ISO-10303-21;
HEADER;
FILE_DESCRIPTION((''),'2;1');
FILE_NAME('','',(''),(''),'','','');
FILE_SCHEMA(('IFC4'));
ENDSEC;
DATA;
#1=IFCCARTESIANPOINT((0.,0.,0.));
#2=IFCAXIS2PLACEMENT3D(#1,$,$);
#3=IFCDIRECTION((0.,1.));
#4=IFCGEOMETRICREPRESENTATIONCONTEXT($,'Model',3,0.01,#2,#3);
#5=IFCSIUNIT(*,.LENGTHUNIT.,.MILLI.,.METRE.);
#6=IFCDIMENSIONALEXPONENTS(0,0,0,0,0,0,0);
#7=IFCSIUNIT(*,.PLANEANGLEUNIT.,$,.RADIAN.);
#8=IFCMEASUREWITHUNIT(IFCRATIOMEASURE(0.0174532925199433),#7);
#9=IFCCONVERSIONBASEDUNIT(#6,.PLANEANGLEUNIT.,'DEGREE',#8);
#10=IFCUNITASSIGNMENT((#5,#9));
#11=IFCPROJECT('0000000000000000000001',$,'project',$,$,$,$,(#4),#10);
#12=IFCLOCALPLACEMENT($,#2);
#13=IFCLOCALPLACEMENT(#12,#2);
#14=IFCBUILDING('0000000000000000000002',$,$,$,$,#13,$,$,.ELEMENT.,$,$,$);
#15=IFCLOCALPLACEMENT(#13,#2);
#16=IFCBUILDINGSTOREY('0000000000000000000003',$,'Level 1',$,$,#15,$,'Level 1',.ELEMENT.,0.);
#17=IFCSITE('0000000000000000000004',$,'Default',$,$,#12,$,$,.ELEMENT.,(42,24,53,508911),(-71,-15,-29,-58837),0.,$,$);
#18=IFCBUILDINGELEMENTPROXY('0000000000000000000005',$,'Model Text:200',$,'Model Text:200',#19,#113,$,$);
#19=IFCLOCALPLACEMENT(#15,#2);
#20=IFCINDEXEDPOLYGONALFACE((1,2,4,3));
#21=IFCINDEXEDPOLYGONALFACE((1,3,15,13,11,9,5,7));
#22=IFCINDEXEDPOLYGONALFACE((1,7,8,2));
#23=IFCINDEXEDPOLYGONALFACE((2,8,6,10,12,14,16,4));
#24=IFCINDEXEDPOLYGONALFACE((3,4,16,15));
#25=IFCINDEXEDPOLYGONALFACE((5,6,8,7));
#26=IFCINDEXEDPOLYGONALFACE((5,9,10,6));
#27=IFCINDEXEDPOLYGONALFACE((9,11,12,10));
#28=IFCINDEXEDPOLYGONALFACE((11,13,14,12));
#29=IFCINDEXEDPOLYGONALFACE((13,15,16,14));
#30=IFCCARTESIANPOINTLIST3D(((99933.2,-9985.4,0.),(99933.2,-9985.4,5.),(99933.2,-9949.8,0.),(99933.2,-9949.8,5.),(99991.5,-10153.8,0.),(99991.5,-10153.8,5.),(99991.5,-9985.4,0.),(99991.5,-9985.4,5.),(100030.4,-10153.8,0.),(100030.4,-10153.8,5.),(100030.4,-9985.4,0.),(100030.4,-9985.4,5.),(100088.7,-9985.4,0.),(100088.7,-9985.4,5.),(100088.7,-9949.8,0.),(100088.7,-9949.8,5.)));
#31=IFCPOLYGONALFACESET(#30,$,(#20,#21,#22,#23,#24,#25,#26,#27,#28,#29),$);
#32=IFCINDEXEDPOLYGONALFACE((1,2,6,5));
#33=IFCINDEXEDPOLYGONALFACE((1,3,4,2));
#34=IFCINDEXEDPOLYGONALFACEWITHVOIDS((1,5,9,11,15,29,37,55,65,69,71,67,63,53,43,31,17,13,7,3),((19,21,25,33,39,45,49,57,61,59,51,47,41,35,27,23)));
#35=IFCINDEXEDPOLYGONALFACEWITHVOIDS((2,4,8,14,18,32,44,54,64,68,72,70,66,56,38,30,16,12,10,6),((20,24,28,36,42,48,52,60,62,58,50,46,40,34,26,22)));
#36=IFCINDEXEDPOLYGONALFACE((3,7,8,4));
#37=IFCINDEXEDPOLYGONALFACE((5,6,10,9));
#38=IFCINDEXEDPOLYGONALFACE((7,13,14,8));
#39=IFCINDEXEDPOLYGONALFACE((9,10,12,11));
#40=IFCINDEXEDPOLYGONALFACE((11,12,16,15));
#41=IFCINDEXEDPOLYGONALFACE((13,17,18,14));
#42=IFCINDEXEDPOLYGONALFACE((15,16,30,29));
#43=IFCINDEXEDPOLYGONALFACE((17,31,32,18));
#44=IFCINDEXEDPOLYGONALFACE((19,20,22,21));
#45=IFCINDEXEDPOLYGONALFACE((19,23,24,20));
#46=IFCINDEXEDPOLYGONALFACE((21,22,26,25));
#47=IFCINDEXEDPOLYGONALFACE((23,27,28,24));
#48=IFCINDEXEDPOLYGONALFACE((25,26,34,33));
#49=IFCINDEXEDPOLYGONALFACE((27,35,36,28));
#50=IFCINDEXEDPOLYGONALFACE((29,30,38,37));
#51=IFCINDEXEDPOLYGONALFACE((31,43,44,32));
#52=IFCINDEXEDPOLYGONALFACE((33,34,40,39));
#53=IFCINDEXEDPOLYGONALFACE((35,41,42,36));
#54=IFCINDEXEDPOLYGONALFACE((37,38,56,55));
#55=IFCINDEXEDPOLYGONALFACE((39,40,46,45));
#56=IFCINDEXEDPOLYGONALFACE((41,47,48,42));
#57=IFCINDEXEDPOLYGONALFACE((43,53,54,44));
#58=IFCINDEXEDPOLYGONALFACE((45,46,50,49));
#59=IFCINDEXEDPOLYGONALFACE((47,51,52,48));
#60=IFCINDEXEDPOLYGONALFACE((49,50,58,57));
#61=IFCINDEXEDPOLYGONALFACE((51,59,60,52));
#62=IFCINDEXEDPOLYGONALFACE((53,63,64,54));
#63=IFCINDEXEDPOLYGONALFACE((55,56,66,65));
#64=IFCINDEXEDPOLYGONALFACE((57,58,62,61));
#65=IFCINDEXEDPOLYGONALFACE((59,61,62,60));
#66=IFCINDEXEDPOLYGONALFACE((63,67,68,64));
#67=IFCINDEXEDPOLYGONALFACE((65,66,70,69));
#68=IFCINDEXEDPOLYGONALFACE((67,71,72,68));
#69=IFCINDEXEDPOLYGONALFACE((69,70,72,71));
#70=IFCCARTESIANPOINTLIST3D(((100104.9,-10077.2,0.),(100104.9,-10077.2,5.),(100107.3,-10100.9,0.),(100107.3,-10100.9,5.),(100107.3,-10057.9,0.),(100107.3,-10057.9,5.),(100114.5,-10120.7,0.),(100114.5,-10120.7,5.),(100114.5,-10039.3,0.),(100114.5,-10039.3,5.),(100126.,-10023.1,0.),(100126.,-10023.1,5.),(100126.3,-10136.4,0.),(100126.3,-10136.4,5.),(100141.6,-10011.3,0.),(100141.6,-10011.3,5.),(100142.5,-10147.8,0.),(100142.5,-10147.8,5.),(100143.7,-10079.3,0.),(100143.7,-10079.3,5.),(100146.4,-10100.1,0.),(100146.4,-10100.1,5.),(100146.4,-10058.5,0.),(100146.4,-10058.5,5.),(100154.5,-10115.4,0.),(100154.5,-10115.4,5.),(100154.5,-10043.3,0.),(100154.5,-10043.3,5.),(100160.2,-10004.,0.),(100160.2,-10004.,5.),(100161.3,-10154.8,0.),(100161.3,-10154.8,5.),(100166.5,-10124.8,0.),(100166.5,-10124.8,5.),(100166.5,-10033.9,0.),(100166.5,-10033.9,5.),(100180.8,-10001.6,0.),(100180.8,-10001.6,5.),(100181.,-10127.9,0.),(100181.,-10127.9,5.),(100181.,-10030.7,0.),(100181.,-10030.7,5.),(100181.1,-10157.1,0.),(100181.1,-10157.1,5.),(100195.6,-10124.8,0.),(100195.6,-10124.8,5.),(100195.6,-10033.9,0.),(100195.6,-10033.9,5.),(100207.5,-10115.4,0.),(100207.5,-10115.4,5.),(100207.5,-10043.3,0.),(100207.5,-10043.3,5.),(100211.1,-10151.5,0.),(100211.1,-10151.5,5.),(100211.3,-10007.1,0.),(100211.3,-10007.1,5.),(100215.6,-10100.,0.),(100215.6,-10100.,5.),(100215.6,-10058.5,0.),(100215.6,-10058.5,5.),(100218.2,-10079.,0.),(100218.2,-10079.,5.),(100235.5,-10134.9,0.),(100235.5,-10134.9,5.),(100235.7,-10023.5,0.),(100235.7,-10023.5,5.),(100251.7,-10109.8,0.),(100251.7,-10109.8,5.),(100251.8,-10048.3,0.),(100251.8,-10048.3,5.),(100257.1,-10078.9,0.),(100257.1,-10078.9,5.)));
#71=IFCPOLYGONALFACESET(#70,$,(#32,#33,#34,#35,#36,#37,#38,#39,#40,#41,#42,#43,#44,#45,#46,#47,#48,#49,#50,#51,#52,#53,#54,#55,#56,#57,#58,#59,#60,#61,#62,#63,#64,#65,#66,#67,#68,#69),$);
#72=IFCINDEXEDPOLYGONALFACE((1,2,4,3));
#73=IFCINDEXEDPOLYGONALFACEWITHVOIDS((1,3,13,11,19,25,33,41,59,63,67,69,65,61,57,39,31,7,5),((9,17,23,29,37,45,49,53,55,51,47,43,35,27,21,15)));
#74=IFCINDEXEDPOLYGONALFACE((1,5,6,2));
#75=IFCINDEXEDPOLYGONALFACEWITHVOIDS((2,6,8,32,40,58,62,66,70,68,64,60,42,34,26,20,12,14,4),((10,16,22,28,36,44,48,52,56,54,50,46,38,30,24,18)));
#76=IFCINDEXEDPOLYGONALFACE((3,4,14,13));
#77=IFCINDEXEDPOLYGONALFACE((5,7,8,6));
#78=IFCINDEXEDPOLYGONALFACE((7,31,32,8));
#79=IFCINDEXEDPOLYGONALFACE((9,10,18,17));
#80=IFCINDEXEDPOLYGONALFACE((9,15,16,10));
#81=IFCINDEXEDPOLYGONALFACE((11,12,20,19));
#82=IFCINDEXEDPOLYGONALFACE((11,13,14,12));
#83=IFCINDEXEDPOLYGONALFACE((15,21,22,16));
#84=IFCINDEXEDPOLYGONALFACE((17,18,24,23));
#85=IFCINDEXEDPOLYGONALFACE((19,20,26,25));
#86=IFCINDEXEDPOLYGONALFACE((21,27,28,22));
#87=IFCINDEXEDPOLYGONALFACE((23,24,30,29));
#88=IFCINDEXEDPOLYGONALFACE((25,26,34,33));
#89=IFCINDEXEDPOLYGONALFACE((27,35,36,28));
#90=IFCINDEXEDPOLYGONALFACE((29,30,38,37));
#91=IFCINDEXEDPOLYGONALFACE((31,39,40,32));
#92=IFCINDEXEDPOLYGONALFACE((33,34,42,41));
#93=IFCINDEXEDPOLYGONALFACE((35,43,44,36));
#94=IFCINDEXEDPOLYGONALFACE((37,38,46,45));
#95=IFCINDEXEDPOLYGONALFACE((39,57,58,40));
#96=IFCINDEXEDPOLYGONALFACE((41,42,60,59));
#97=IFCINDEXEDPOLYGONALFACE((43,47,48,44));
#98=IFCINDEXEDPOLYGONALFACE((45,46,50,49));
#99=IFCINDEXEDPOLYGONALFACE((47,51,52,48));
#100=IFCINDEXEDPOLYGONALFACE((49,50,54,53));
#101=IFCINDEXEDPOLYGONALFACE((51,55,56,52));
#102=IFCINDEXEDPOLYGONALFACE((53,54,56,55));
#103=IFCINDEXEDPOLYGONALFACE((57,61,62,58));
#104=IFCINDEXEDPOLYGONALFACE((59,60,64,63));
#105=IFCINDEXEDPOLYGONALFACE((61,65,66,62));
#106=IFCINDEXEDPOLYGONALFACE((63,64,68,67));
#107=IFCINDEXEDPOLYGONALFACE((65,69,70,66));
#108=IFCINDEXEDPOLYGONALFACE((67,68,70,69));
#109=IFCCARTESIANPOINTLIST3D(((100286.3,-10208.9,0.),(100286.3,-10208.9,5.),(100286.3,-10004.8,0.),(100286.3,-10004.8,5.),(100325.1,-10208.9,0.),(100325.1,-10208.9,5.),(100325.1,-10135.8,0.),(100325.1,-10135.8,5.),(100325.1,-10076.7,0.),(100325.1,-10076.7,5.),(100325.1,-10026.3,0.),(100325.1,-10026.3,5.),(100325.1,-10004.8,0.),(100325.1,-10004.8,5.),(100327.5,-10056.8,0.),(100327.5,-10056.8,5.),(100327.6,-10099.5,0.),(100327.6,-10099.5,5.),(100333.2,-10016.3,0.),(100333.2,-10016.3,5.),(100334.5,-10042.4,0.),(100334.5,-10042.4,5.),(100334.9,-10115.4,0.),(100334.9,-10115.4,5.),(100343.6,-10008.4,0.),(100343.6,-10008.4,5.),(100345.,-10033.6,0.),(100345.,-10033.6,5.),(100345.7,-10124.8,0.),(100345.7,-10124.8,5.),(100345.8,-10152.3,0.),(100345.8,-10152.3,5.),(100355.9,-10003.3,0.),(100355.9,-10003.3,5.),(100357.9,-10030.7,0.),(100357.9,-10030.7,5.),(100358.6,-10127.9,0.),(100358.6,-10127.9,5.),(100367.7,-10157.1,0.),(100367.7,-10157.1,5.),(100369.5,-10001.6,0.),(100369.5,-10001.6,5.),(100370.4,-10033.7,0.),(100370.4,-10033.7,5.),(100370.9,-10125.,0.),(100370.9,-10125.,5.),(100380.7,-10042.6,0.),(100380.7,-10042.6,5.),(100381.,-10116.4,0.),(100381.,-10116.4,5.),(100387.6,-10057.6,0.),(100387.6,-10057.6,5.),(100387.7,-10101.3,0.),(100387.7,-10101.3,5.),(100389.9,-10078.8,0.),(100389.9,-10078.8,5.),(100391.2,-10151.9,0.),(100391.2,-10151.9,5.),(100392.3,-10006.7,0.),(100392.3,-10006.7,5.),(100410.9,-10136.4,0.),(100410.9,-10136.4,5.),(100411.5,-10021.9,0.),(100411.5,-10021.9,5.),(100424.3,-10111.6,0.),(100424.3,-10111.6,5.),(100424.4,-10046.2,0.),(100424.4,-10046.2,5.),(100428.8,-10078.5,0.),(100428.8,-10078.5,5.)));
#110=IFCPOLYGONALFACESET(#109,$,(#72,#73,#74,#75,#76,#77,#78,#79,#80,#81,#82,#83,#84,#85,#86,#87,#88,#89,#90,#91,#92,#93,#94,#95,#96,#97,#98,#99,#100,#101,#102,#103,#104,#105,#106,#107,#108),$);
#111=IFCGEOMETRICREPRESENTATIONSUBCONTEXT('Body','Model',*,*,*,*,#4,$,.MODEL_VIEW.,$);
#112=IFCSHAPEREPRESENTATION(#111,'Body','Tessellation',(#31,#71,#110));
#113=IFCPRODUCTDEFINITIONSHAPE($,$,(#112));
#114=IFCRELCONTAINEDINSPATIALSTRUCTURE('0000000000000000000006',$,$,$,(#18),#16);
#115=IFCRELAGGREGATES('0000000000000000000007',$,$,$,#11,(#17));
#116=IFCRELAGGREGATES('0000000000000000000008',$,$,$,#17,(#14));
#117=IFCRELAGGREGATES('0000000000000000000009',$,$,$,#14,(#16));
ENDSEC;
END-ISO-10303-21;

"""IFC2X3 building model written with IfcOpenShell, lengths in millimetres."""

from ifc_helpers import new_model, entity, si_unit, converted_unit, direction, frame, origin, place, context, subcontext, project, spatial, polyline, outline, extrude, element, save


model = new_model("IFC2X3")

# Units and contexts
model_context = context("Model", 3, precision=0.01, world=origin(), true_north=direction((0.0, 1.0)))
body_context = subcontext(model_context, "Body", "Model", "MODEL_VIEW")
ifc_project = project(units=[si_unit("LENGTHUNIT", "METRE", prefix="MILLI"), converted_unit("PLANEANGLEUNIT", "DEGREE", entity("IfcRatioMeasure", 0.0174532925199433), si_unit("PLANEANGLEUNIT", "RADIAN"), dimensions=[0, 0, 0, 0, 0, 0, 0])], contexts=[model_context])

# Site, building, storey
site_placement = place(None, origin())
site = spatial("IfcSite", under=ifc_project, at=site_placement, Name="Default", CompositionType="ELEMENT", RefLatitude=(42, 24, 53, 508911), RefLongitude=(-71, -15, -29, -58837), RefElevation=0.0)
building_placement = place(site_placement, origin())
building = spatial("IfcBuilding", under=site, at=building_placement, CompositionType="ELEMENT")
storey_placement = place(building_placement, origin())
storey = spatial("IfcBuildingStorey", under=building, at=storey_placement, Name="Level 1", LongName="Level 1", CompositionType="ELEMENT", Elevation=0.0)

# Building element proxy
proxy_1_placement = place(storey_placement, origin())
element("IfcBuildingElementProxy", 1, at=proxy_1_placement, inside=storey, Name="Model Text:200", ObjectType="Model Text:200", context=body_context, shape_type="SweptSolid", body=[
    extrude(outline(polyline([(-19.4, -135.2), (19.4, -135.2), (19.4, 33.2), (77.7, 33.2), (77.7, 68.8), (-77.7, 68.8), (-77.7, 33.2), (-19.4, 33.2), (-19.4, -135.2)])), frame((100010.9, -10018.6, 0.0)), (0.0, 0.0, 1.0), 5.0),
    extrude(outline(polyline([(-8.8, -65.7), (15.1, -65.7), (35.5, -60.5), (52.3, -50.4), (65.3, -35.4), (74.1, -17.3), (78.4, 2.1), (75.9, 32.5), (61.8, 58.5), (38.4, 77.1), (8.3, 85.6), (-22.7, 83.3), (-49.0, 69.9), (-67.8, 47.3), (-76.3, 17.5), (-76.0, -3.3), (-70.7, -22.5), (-60.5, -39.2), (-45.5, -52.3), (-27.7, -61.4), (-8.8, -65.7)]), holes=[polyline([(-2.7, -27.2), (-23.1, -22.5), (-37.5, -12.9), (-45.7, 0.0), (-47.3, 14.8), (-42.7, 28.9), (-32.2, 39.9), (-16.3, 46.3), (4.5, 46.9), (25.1, 42.1), (39.6, 32.6), (47.7, 19.7), (49.4, 5.0), (44.8, -9.2), (34.2, -20.2), (18.2, -26.7), (-2.7, -27.2)])]), frame((100171.1, -10079.3, 0.0), z_axis=(0.0, 0.0, 1.0), x_axis=(0.100608, -0.994926, 0.0)), (0.0, 0.0, 1.0), 5.0),
    extrude(outline(polyline([(-73.1, -75.4), (130.9, -75.4), (130.9, -36.6), (57.8, -36.6), (74.3, -15.9), (79.1, 6.0), (73.9, 29.5), (58.4, 49.2), (33.6, 62.6), (0.5, 67.1), (-31.8, 62.8), (-56.1, 49.8), (-71.3, 30.7), (-76.4, 7.8), (-74.7, -5.8), (-69.6, -18.1), (-61.7, -28.5), (-51.7, -36.6), (-73.1, -36.6), (-73.1, -75.4)]), holes=[polyline([(-1.2, -36.6), (-21.2, -34.2), (-35.6, -27.2), (-44.3, -16.7), (-47.2, -3.8), (-44.3, 8.7), (-35.4, 19.0), (-20.4, 25.9), (0.8, 28.2), (23.3, 26.0), (38.5, 19.3), (47.1, 9.2), (49.9, -3.1), (46.8, -16.0), (37.4, -26.8), (21.5, -34.1), (-1.2, -36.6)])]), frame((100361.7, -10078.0, 0.0), z_axis=(0.0, 0.0, 1.0), x_axis=(0.0, -1.0, 0.0)), (0.0, 0.0, 1.0), 5.0),
])

save(model, "model.ifc")
